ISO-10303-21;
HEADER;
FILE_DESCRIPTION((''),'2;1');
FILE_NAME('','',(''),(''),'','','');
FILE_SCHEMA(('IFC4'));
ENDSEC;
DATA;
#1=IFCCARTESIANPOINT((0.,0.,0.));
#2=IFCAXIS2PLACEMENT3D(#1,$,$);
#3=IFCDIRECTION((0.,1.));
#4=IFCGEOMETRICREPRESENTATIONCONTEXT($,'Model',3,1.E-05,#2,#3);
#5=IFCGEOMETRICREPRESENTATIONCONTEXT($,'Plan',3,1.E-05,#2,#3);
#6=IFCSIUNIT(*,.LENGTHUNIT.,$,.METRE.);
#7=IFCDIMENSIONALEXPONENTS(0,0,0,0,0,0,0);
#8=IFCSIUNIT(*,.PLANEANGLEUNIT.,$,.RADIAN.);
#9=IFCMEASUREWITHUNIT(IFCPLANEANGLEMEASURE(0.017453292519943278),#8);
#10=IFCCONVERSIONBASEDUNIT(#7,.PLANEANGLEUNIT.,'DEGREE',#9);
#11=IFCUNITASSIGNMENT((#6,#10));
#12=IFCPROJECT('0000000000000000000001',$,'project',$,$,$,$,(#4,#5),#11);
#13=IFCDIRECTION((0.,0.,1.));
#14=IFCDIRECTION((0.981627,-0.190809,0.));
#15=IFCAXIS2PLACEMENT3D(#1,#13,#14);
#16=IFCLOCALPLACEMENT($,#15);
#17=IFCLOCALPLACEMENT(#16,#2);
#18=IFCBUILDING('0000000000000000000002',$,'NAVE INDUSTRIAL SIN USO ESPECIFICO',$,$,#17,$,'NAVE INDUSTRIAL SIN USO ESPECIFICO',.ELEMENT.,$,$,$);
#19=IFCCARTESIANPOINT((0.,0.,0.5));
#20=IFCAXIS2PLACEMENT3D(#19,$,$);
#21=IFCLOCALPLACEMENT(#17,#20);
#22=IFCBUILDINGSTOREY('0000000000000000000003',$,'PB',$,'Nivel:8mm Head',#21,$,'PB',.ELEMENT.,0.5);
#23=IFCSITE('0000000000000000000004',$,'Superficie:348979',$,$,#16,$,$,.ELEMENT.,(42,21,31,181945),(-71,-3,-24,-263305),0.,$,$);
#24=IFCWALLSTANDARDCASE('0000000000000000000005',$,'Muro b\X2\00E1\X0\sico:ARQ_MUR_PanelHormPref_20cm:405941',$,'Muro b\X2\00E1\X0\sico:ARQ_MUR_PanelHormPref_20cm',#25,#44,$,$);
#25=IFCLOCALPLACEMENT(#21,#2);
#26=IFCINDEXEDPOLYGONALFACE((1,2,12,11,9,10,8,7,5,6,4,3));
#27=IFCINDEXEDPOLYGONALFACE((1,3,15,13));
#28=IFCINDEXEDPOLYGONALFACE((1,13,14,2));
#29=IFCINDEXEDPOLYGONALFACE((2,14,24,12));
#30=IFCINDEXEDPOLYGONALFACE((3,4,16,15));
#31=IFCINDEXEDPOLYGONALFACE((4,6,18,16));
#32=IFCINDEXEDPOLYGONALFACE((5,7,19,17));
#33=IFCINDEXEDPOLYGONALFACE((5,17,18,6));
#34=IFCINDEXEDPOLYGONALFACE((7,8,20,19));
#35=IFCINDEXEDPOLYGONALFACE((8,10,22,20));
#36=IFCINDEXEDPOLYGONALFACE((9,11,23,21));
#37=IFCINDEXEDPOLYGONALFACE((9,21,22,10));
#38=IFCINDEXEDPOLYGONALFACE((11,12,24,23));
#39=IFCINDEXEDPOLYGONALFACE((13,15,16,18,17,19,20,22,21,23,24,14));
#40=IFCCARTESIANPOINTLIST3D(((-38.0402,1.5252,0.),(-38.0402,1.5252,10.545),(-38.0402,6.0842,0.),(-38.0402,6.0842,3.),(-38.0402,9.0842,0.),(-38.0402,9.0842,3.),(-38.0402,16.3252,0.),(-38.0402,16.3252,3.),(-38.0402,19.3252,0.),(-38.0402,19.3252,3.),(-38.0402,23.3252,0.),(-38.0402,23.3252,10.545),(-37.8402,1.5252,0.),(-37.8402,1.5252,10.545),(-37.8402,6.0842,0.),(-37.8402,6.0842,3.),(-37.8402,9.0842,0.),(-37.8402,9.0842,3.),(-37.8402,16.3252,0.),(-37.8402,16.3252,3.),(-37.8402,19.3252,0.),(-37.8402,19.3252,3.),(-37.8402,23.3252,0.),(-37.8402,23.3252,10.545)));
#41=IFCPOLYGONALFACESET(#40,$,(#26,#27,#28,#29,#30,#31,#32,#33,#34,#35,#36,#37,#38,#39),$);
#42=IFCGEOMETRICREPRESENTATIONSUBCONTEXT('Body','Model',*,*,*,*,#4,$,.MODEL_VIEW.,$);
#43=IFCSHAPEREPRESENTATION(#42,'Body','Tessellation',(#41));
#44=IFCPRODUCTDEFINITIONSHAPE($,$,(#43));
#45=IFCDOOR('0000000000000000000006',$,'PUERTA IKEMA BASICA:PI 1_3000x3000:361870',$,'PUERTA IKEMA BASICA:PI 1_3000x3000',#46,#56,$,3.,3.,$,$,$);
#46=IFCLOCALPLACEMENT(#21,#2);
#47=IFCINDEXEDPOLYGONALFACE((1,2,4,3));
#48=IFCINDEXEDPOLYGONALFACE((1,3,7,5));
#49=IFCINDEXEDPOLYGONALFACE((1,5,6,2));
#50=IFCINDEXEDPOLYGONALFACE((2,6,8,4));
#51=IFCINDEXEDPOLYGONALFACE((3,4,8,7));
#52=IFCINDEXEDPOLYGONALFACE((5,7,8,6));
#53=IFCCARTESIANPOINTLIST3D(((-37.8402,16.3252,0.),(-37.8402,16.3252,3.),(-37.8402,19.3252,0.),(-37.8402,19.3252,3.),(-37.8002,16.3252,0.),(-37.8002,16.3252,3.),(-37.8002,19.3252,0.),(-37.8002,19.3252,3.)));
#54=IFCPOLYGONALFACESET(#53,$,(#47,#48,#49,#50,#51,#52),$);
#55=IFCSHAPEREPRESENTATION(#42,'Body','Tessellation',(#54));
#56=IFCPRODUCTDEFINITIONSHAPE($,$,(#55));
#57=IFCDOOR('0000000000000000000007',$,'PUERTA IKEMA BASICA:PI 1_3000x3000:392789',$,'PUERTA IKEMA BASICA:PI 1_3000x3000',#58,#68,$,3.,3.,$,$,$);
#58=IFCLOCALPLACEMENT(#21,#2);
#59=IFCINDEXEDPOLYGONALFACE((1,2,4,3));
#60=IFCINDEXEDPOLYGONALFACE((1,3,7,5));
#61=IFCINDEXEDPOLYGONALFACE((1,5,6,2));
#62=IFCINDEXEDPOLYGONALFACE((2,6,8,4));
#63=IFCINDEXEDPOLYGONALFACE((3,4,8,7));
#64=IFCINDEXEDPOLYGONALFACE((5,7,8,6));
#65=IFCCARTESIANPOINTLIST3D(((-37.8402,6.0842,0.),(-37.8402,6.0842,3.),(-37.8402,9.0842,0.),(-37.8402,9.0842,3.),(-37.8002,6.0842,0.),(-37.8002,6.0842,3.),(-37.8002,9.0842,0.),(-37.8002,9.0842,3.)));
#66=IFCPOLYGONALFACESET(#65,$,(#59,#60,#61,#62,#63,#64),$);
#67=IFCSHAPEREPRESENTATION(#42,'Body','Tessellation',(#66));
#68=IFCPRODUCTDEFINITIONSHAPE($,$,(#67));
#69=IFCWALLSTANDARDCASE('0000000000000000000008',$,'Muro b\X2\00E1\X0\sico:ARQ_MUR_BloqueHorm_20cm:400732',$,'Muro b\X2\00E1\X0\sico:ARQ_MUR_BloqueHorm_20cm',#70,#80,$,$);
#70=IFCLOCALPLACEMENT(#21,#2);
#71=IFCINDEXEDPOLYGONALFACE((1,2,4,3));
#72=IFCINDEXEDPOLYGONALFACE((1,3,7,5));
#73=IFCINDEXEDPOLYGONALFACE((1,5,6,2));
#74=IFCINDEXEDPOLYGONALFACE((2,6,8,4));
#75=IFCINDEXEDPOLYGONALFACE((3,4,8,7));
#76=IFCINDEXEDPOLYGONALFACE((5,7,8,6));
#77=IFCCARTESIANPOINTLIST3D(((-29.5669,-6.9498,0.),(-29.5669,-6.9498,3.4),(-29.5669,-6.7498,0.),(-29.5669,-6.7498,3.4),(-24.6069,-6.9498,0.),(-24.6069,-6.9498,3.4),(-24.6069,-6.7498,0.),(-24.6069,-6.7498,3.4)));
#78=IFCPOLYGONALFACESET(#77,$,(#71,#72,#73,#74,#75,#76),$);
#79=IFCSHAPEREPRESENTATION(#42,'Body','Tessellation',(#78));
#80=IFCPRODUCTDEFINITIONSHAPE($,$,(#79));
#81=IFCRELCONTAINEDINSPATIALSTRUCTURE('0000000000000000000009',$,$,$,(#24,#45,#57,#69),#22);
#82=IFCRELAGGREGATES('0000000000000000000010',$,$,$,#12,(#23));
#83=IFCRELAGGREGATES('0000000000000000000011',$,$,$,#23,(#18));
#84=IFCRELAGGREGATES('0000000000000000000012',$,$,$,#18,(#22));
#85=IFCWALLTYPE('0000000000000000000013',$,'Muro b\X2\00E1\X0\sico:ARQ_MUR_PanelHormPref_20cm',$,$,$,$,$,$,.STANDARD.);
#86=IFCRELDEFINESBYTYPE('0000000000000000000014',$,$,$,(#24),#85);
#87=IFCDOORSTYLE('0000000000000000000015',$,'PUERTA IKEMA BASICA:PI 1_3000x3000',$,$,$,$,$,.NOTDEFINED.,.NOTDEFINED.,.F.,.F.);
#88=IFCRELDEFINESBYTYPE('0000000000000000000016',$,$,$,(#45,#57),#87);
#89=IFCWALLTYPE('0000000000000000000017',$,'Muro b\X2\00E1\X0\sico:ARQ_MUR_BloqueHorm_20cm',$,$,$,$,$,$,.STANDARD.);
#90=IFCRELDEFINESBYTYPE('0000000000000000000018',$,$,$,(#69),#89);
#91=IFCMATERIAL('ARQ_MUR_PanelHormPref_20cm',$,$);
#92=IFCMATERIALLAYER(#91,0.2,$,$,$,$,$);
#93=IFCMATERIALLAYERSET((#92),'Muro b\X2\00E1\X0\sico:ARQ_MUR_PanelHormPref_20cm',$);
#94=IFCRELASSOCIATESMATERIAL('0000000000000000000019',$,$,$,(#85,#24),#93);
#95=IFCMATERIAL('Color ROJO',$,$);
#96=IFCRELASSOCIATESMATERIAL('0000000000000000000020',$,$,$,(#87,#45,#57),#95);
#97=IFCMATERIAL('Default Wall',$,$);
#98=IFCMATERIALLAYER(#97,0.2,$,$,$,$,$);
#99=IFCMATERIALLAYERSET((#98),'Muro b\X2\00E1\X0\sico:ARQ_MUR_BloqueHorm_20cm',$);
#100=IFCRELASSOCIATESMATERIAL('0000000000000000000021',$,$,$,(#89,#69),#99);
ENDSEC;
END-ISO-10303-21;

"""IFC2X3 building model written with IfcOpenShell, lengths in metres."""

from ifc_helpers import new_model, entity, si_unit, converted_unit, direction, frame, frame_2d, origin, place, context, subcontext, project, spatial, polyline, rectangle, extrude, clip, bounded_halfspace, source, transform, mapped, material, layer, layer_set, layer_usage, type_object, type_shapes, element, fill, save


model = new_model("IFC2X3")

# Units and contexts
model_context = context("Model", 3, precision=1e-05, world=origin(), true_north=direction((0.0, 1.0)))
plan_context = context("Plan", 3, precision=1e-05, world=origin(), true_north=direction((0.0, 1.0)))
body_context = subcontext(model_context, "Body", "Model", "MODEL_VIEW")
ifc_project = project(units=[si_unit("LENGTHUNIT", "METRE"), converted_unit("PLANEANGLEUNIT", "DEGREE", entity("IfcPlaneAngleMeasure", 0.017453292519943278), si_unit("PLANEANGLEUNIT", "RADIAN"), dimensions=[0, 0, 0, 0, 0, 0, 0])], contexts=[model_context, plan_context])

# Site, building, storey
site_placement = place(None, frame((0.0, 0.0, 0.0), z_axis=(0.0, 0.0, 1.0), x_axis=(0.981627, -0.190809, 0.0)))
site = spatial("IfcSite", under=ifc_project, at=site_placement, Name="Superficie:348979", CompositionType="ELEMENT", RefLatitude=(42, 21, 31, 181945), RefLongitude=(-71, -3, -24, -263305), RefElevation=0.0)
building_placement = place(site_placement, origin())
building = spatial("IfcBuilding", under=site, at=building_placement, Name="NAVE INDUSTRIAL SIN USO ESPECIFICO", LongName="NAVE INDUSTRIAL SIN USO ESPECIFICO", CompositionType="ELEMENT")
storey_placement = place(building_placement, frame((0.0, 0.0, 0.5)))
storey = spatial("IfcBuildingStorey", under=building, at=storey_placement, Name="PB", ObjectType="Nivel:8mm Head", LongName="PB", CompositionType="ELEMENT", Elevation=0.5)

# Shared definitions
ifc_material_1 = material(Name="Color ROJO")

# Wall, openings, doors
ifc_material_2 = material(Name="ARQ_MUR_PanelHormPref_20cm")
ifc_layer_1 = layer(ifc_material_2, 0.2)
ifc_layer_set_1 = layer_set([ifc_layer_1], Name="Muro básico:ARQ_MUR_PanelHormPref_20cm")
ifc_layer_usage_1 = layer_usage(ifc_layer_set_1, "AXIS2", "NEGATIVE", 0.1)
wall_type_1 = type_object("IfcWallType", Name="Muro básico:ARQ_MUR_PanelHormPref_20cm", PredefinedType="STANDARD", material=ifc_layer_set_1)
wall_1_placement = place(storey_placement, frame((-37.9402, 1.5252, 0.0), z_axis=(0.0, 0.0, 1.0), x_axis=(0.0, 1.0, 0.0)))
wall_1 = element("IfcWallStandardCase", 1, at=wall_1_placement, inside=storey, type_object=wall_type_1, material=ifc_layer_usage_1, Name="Muro básico:ARQ_MUR_PanelHormPref_20cm:405941", ObjectType="Muro básico:ARQ_MUR_PanelHormPref_20cm", context=body_context, shape_type="SweptSolid", body=[
    extrude(rectangle(XDim=21.8, YDim=0.2, at=frame_2d((10.9, 0.0), x_axis=(1.0, 0.0))), origin(), (0.0, 0.0, 1.0), 10.545),
])
opening_1_placement = place(wall_1_placement, frame((14.8, -0.1, 0.0)))
opening_1 = element("IfcOpeningElement", 2, at=opening_1_placement, cuts=wall_1, ObjectType="Opening", context=body_context, shape_type="SweptSolid", body=[
    extrude(rectangle(XDim=3.0, YDim=3.0, at=frame_2d((1.5, 1.5), x_axis=(1.0, 0.0))), frame((0.0, 0.0, 0.0), z_axis=(0.0, 1.0, 0.0), x_axis=(0.0, 0.0, 1.0)), (0.0, 0.0, 1.0), 0.2),
])
opening_2_placement = place(wall_1_placement, frame((-1.5252, -37.9402, 0.0), z_axis=(0.0, 0.0, 1.0), x_axis=(0.0, -1.0, 0.0)))
element("IfcOpeningElement", 3, at=opening_2_placement, cuts=wall_1, ObjectType="Opening", context=body_context, shape_type="SweptSolid", body=[
    extrude(rectangle(XDim=3.0, YDim=3.0, at=frame_2d((0.0, 0.0), x_axis=(0.0, 1.0))), frame((-36.3162, 17.8252, 1.5), z_axis=(-1.0, 0.0, 0.0), x_axis=(0.0, -1.0, 0.0)), (0.0, 0.0, 1.0), 3.048),
])
opening_3_placement = place(wall_1_placement, frame((4.559, -0.1, 0.0)))
opening_3 = element("IfcOpeningElement", 4, at=opening_3_placement, cuts=wall_1, ObjectType="Opening", context=body_context, shape_type="SweptSolid", body=[
    extrude(rectangle(XDim=3.0, YDim=3.0, at=frame_2d((1.5, 1.5), x_axis=(1.0, 0.0))), frame((0.0, 0.0, 0.0), z_axis=(0.0, 1.0, 0.0), x_axis=(0.0, 0.0, 1.0)), (0.0, 0.0, 1.0), 0.2),
])
opening_4_placement = place(wall_1_placement, frame((-1.5252, -37.9402, 0.0), z_axis=(0.0, 0.0, 1.0), x_axis=(0.0, -1.0, 0.0)))
element("IfcOpeningElement", 5, at=opening_4_placement, cuts=wall_1, ObjectType="Opening", context=body_context, shape_type="SweptSolid", body=[
    extrude(rectangle(XDim=3.0, YDim=3.0, at=frame_2d((0.0, 0.0), x_axis=(0.0, 1.0))), frame((-36.3162, 7.5842, 1.5), z_axis=(-1.0, 0.0, 0.0), x_axis=(0.0, -1.0, 0.0)), (0.0, 0.0, 1.0), 3.048),
])
door_style_1 = type_object("IfcDoorStyle", Name="PUERTA IKEMA BASICA:PI 1_3000x3000", ConstructionType="NOTDEFINED", OperationType="NOTDEFINED", ParameterTakesPrecedence=False, Sizeable=False, material=ifc_material_1)
shared_shape_1 = source(origin(), body_context, "Body", "SweptSolid", [
    extrude(rectangle(XDim=0.04, YDim=3.0, at=frame_2d((0.0, 0.0), x_axis=(1.0, 0.0))), frame((1.5, -0.02, 0.0), z_axis=(0.0, 0.0, 1.0), x_axis=(0.0, 1.0, 0.0)), (0.0, 0.0, 1.0), 3.0),
])
type_shapes(door_style_1, [shared_shape_1])
door_1_placement = place(opening_1_placement, origin())
door_1 = element("IfcDoor", 6, at=door_1_placement, inside=storey, type_object=door_style_1, material=ifc_material_1, Name="PUERTA IKEMA BASICA:PI 1_3000x3000:361870", ObjectType="PUERTA IKEMA BASICA:PI 1_3000x3000", OverallHeight=3.0, OverallWidth=3.0, context=body_context, shape_type="MappedRepresentation", body=[
    mapped(shared_shape_1, transform((0.0, 0.0, 0.0), scale=1.0)),
])
fill(opening_1, door_1)
door_2_placement = place(opening_3_placement, origin())
door_2 = element("IfcDoor", 7, at=door_2_placement, inside=storey, type_object=door_style_1, material=ifc_material_1, Name="PUERTA IKEMA BASICA:PI 1_3000x3000:392789", ObjectType="PUERTA IKEMA BASICA:PI 1_3000x3000", OverallHeight=3.0, OverallWidth=3.0, context=body_context, shape_type="MappedRepresentation", body=[
    mapped(shared_shape_1, transform((0.0, 0.0, 0.0), scale=1.0)),
])
fill(opening_3, door_2)

# Wall
ifc_material_3 = material(Name="Default Wall")
ifc_layer_2 = layer(ifc_material_3, 0.2)
ifc_layer_set_2 = layer_set([ifc_layer_2], Name="Muro básico:ARQ_MUR_BloqueHorm_20cm")
ifc_layer_usage_2 = layer_usage(ifc_layer_set_2, "AXIS2", "POSITIVE", -0.1)
wall_type_2 = type_object("IfcWallType", Name="Muro básico:ARQ_MUR_BloqueHorm_20cm", PredefinedType="STANDARD", material=ifc_layer_set_2)
wall_2_placement = place(storey_placement, frame((-29.5669, -6.8498, 0.0)))
element("IfcWallStandardCase", 8, at=wall_2_placement, inside=storey, type_object=wall_type_2, material=ifc_layer_usage_2, Name="Muro básico:ARQ_MUR_BloqueHorm_20cm:400732", ObjectType="Muro básico:ARQ_MUR_BloqueHorm_20cm", context=body_context, shape_type="Clipping", body=[
    clip(extrude(rectangle(XDim=4.96, YDim=0.2, at=frame_2d((2.48, 0.0), x_axis=(-1.0, 0.0))), origin(), (0.0, 0.0, 1.0), 3.4), bounded_halfspace(frame((0.0, -0.1, 3.4), z_axis=(0.0, 0.0, -1.0), x_axis=(1.0, 0.0, 0.0)), True, frame((0.0, -0.1, 3.4)), polyline([(0.0, 0.0), (4.96, 0.0), (4.96, 0.2), (0.0, 0.2), (0.0, 0.0)]))),
])

save(model, "model.ifc")
